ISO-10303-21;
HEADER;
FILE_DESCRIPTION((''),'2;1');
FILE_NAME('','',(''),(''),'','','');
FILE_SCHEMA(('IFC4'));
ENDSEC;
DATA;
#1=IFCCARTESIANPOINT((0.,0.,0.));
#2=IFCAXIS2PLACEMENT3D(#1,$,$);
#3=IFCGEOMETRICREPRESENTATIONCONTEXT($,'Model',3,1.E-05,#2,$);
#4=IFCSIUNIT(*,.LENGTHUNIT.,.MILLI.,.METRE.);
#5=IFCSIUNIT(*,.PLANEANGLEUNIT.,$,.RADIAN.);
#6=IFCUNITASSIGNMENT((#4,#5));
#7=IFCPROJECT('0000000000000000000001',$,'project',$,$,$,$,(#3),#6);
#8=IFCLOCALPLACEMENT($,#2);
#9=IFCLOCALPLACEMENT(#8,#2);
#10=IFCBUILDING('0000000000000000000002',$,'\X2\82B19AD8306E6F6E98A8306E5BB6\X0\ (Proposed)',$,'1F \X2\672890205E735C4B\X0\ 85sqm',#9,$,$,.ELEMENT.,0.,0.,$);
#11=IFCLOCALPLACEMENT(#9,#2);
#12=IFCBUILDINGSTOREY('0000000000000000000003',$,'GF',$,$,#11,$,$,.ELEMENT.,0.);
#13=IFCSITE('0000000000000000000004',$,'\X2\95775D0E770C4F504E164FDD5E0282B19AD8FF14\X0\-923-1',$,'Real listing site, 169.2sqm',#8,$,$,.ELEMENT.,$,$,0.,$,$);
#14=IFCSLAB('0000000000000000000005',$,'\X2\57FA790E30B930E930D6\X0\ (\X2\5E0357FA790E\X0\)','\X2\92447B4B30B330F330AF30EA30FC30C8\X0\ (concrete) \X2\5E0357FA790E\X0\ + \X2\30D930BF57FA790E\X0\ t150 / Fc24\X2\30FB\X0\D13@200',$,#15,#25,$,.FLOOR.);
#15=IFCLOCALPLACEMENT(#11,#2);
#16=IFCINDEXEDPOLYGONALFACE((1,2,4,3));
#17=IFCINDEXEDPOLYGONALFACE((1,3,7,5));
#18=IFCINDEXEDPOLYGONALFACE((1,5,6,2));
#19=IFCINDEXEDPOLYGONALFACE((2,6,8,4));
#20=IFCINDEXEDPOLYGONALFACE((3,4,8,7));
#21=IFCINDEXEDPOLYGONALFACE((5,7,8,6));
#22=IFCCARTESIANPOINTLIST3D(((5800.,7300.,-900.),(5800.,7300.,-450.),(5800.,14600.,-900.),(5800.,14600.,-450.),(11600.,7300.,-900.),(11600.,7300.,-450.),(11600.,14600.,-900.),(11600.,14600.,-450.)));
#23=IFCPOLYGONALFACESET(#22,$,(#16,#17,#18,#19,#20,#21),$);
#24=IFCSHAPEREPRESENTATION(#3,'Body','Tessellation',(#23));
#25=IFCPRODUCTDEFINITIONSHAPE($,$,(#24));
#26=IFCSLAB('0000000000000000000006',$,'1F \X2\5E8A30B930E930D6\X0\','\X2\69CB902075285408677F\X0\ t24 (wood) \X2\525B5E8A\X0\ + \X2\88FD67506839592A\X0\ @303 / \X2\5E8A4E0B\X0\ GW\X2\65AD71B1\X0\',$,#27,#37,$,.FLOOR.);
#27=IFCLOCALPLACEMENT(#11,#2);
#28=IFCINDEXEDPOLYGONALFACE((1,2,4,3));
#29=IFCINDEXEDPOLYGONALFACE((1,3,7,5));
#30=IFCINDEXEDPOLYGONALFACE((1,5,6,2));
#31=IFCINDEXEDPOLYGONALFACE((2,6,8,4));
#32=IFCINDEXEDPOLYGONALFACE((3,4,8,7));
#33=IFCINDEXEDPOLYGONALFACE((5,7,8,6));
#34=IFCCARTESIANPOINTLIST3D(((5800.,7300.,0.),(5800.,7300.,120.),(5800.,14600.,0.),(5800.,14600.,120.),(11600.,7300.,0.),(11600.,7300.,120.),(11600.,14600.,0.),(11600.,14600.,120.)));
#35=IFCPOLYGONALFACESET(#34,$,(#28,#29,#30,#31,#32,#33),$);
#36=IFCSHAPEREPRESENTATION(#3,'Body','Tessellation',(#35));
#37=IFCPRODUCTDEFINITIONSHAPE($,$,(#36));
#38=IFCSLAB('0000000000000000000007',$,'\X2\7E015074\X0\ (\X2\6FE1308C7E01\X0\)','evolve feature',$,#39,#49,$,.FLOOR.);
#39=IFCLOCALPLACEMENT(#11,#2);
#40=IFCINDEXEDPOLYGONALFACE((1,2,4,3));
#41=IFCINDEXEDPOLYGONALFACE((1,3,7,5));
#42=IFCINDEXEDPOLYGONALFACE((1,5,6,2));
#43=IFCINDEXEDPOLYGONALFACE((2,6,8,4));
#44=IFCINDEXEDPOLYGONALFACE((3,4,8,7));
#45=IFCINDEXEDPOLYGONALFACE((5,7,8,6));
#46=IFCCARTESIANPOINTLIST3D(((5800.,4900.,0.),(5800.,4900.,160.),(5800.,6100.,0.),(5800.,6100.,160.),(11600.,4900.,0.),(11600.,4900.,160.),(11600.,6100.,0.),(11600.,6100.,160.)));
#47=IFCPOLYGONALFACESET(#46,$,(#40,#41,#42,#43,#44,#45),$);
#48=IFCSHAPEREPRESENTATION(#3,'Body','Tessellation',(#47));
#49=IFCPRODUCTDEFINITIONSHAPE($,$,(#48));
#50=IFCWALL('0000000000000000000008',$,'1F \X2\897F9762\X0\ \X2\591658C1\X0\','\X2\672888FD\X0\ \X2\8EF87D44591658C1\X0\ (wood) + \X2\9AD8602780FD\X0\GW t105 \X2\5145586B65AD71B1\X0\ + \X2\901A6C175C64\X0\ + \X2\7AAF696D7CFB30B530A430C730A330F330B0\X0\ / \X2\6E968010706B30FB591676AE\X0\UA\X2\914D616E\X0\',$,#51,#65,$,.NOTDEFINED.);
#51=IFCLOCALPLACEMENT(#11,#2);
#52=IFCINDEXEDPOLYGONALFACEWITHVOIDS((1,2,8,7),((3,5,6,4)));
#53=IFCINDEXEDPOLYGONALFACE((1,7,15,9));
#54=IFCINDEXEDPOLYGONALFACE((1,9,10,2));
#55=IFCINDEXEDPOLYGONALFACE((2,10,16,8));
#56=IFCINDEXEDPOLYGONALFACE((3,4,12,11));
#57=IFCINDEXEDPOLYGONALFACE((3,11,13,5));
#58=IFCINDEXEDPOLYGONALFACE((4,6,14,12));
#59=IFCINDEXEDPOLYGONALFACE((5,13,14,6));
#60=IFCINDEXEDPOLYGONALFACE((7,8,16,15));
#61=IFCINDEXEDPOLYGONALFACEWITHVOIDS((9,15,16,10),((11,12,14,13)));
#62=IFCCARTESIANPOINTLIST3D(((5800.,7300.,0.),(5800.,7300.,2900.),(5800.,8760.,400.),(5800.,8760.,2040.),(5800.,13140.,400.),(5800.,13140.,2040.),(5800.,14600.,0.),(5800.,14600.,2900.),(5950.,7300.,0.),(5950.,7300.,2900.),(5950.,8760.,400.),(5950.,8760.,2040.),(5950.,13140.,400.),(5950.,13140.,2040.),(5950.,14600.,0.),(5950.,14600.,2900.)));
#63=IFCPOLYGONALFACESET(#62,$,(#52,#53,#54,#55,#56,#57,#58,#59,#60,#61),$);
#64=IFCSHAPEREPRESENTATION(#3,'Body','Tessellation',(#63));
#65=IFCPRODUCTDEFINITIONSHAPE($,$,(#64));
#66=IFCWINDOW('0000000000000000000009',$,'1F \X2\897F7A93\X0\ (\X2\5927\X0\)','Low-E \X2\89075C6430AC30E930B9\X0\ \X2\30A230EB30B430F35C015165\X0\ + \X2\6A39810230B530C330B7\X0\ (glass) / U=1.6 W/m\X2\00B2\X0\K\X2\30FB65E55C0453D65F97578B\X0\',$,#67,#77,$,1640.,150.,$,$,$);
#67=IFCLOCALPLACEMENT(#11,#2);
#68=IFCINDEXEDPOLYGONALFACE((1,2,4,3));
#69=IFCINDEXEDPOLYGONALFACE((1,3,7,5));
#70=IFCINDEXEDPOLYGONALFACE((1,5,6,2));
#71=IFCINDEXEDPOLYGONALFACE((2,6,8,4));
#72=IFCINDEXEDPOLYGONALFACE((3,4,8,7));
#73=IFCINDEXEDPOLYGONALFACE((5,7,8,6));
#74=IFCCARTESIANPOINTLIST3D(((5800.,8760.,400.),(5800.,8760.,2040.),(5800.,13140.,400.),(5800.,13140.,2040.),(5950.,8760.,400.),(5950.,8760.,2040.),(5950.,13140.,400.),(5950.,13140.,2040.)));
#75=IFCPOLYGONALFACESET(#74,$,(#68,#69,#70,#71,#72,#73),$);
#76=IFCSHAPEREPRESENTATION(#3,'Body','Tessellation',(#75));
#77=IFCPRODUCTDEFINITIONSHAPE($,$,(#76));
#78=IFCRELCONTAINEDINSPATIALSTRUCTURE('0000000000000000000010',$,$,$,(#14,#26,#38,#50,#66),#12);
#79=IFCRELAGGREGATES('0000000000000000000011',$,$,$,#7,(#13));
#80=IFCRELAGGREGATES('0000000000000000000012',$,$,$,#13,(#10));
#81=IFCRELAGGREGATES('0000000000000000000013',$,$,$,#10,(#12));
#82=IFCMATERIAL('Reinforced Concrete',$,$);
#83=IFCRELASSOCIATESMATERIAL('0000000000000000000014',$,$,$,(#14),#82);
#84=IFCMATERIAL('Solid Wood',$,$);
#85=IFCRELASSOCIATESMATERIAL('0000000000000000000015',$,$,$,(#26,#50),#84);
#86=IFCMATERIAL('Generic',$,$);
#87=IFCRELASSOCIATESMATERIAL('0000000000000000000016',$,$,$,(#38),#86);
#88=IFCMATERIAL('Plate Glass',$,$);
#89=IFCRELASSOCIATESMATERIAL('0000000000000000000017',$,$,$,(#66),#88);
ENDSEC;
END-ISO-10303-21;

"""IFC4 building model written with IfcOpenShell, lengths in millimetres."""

from ifc_helpers import new_model, si_unit, frame, frame_2d, origin, place, context, project, spatial, rectangle, extrude, material, element, fill, save


model = new_model("IFC4")

# Units and contexts
model_context = context("Model", 3, precision=1e-05, world=origin())
ifc_project = project(units=[si_unit("LENGTHUNIT", "METRE", prefix="MILLI"), si_unit("PLANEANGLEUNIT", "RADIAN")], contexts=[model_context])

# Site, building, storey
site_placement = place(None, origin())
site = spatial("IfcSite", under=ifc_project, at=site_placement, Name="長崎県佐世保市花高４-923-1", ObjectType="Real listing site, 169.2sqm", CompositionType="ELEMENT", RefElevation=0.0)
building_placement = place(site_placement, origin())
building = spatial("IfcBuilding", under=site, at=building_placement, Name="花高の潮風の家 (Proposed)", ObjectType="1F 木造平屋 85sqm", CompositionType="ELEMENT", ElevationOfRefHeight=0.0, ElevationOfTerrain=0.0)
storey_placement = place(building_placement, origin())
storey = spatial("IfcBuildingStorey", under=building, at=storey_placement, Name="GF", CompositionType="ELEMENT", Elevation=0.0)

# Slabs
ifc_material_1 = material(Name="Reinforced Concrete")
slab_1_placement = place(storey_placement, frame((2900.0, 3650.0, -450.0)))
element("IfcSlab", 1, at=slab_1_placement, inside=storey, material=ifc_material_1, Name="基礎スラブ (布基礎)", Description="鉄筋コンクリート (concrete) 布基礎 + ベタ基礎 t150 / Fc24・D13@200", PredefinedType="FLOOR", context=model_context, shape_type="SweptSolid", body=[
    extrude(rectangle(XDim=5800.0, YDim=7300.0, at=frame_2d((2900.0, 3650.0))), frame((2900.0, 3650.0, -450.0)), (0.0, 0.0, 1.0), 450.0),
])
ifc_material_2 = material(Name="Solid Wood")
slab_2_placement = place(storey_placement, frame((2900.0, 3650.0, 0.0)))
element("IfcSlab", 2, at=slab_2_placement, inside=storey, material=ifc_material_2, Name="1F 床スラブ", Description="構造用合板 t24 (wood) 剛床 + 製材根太 @303 / 床下 GW断熱", PredefinedType="FLOOR", context=model_context, shape_type="SweptSolid", body=[
    extrude(rectangle(XDim=5800.0, YDim=7300.0, at=frame_2d((2900.0, 3650.0))), frame((2900.0, 3650.0, 0.0)), (0.0, 0.0, 1.0), 120.0),
])
ifc_material_3 = material(Name="Generic")
slab_3_placement = place(storey_placement, frame((2900.0, 2450.0, 0.0)))
element("IfcSlab", 3, at=slab_3_placement, inside=storey, material=ifc_material_3, Name="縁側 (濡れ縁)", Description="evolve feature", PredefinedType="FLOOR", context=model_context, shape_type="SweptSolid", body=[
    extrude(rectangle(XDim=5800.0, YDim=1200.0, at=frame_2d((2900.0, 600.0))), frame((2900.0, 2450.0, 0.0)), (0.0, 0.0, 1.0), 160.0),
])

# Shared definitions
ifc_material_4 = material(Name="Plate Glass")

# Wall, opening, window
wall_1_placement = place(storey_placement, frame((2900.0, 3650.0, 0.0)))
wall_1 = element("IfcWall", 4, at=wall_1_placement, inside=storey, material=ifc_material_2, Name="1F 西面 外壁", Description="木製 軸組外壁 (wood) + 高性能GW t105 充填断熱 + 通気層 + 窯業系サイディング / 準耐火・外皮UA配慮", PredefinedType="NOTDEFINED", context=model_context, shape_type="SweptSolid", body=[
    extrude(rectangle(XDim=150.0, YDim=7300.0, at=frame_2d((75.0, 3650.0))), frame((2900.0, 3650.0, 0.0)), (0.0, 0.0, 1.0), 2900.0),
])
opening_1_placement = place(storey_placement, frame((2900.0, 4380.0, 200.0)))
opening_1 = element("IfcOpeningElement", 5, at=opening_1_placement, cuts=wall_1, PredefinedType="NOTDEFINED", context=model_context, shape_type="SweptSolid", body=[
    extrude(rectangle(XDim=150.0, YDim=4380.0, at=frame_2d((75.0, 2190.0))), frame((2900.0, 4380.0, 200.0)), (0.0, 0.0, 1.0), 1640.0),
])
window_1_placement = place(storey_placement, frame((2900.0, 4380.0, 200.0)))
window_1 = element("IfcWindow", 6, at=window_1_placement, inside=storey, material=ifc_material_4, Name="1F 西窓 (大)", Description="Low-E 複層ガラス アルゴン封入 + 樹脂サッシ (glass) / U=1.6 W/m²K・日射取得型", OverallHeight=1640.0, OverallWidth=150.0, context=model_context, shape_type="SweptSolid", body=[
    extrude(rectangle(XDim=150.0, YDim=4380.0, at=frame_2d((75.0, 2190.0))), frame((2900.0, 4380.0, 200.0)), (0.0, 0.0, 1.0), 1640.0),
])
fill(opening_1, window_1)

save(model, "model.ifc")
